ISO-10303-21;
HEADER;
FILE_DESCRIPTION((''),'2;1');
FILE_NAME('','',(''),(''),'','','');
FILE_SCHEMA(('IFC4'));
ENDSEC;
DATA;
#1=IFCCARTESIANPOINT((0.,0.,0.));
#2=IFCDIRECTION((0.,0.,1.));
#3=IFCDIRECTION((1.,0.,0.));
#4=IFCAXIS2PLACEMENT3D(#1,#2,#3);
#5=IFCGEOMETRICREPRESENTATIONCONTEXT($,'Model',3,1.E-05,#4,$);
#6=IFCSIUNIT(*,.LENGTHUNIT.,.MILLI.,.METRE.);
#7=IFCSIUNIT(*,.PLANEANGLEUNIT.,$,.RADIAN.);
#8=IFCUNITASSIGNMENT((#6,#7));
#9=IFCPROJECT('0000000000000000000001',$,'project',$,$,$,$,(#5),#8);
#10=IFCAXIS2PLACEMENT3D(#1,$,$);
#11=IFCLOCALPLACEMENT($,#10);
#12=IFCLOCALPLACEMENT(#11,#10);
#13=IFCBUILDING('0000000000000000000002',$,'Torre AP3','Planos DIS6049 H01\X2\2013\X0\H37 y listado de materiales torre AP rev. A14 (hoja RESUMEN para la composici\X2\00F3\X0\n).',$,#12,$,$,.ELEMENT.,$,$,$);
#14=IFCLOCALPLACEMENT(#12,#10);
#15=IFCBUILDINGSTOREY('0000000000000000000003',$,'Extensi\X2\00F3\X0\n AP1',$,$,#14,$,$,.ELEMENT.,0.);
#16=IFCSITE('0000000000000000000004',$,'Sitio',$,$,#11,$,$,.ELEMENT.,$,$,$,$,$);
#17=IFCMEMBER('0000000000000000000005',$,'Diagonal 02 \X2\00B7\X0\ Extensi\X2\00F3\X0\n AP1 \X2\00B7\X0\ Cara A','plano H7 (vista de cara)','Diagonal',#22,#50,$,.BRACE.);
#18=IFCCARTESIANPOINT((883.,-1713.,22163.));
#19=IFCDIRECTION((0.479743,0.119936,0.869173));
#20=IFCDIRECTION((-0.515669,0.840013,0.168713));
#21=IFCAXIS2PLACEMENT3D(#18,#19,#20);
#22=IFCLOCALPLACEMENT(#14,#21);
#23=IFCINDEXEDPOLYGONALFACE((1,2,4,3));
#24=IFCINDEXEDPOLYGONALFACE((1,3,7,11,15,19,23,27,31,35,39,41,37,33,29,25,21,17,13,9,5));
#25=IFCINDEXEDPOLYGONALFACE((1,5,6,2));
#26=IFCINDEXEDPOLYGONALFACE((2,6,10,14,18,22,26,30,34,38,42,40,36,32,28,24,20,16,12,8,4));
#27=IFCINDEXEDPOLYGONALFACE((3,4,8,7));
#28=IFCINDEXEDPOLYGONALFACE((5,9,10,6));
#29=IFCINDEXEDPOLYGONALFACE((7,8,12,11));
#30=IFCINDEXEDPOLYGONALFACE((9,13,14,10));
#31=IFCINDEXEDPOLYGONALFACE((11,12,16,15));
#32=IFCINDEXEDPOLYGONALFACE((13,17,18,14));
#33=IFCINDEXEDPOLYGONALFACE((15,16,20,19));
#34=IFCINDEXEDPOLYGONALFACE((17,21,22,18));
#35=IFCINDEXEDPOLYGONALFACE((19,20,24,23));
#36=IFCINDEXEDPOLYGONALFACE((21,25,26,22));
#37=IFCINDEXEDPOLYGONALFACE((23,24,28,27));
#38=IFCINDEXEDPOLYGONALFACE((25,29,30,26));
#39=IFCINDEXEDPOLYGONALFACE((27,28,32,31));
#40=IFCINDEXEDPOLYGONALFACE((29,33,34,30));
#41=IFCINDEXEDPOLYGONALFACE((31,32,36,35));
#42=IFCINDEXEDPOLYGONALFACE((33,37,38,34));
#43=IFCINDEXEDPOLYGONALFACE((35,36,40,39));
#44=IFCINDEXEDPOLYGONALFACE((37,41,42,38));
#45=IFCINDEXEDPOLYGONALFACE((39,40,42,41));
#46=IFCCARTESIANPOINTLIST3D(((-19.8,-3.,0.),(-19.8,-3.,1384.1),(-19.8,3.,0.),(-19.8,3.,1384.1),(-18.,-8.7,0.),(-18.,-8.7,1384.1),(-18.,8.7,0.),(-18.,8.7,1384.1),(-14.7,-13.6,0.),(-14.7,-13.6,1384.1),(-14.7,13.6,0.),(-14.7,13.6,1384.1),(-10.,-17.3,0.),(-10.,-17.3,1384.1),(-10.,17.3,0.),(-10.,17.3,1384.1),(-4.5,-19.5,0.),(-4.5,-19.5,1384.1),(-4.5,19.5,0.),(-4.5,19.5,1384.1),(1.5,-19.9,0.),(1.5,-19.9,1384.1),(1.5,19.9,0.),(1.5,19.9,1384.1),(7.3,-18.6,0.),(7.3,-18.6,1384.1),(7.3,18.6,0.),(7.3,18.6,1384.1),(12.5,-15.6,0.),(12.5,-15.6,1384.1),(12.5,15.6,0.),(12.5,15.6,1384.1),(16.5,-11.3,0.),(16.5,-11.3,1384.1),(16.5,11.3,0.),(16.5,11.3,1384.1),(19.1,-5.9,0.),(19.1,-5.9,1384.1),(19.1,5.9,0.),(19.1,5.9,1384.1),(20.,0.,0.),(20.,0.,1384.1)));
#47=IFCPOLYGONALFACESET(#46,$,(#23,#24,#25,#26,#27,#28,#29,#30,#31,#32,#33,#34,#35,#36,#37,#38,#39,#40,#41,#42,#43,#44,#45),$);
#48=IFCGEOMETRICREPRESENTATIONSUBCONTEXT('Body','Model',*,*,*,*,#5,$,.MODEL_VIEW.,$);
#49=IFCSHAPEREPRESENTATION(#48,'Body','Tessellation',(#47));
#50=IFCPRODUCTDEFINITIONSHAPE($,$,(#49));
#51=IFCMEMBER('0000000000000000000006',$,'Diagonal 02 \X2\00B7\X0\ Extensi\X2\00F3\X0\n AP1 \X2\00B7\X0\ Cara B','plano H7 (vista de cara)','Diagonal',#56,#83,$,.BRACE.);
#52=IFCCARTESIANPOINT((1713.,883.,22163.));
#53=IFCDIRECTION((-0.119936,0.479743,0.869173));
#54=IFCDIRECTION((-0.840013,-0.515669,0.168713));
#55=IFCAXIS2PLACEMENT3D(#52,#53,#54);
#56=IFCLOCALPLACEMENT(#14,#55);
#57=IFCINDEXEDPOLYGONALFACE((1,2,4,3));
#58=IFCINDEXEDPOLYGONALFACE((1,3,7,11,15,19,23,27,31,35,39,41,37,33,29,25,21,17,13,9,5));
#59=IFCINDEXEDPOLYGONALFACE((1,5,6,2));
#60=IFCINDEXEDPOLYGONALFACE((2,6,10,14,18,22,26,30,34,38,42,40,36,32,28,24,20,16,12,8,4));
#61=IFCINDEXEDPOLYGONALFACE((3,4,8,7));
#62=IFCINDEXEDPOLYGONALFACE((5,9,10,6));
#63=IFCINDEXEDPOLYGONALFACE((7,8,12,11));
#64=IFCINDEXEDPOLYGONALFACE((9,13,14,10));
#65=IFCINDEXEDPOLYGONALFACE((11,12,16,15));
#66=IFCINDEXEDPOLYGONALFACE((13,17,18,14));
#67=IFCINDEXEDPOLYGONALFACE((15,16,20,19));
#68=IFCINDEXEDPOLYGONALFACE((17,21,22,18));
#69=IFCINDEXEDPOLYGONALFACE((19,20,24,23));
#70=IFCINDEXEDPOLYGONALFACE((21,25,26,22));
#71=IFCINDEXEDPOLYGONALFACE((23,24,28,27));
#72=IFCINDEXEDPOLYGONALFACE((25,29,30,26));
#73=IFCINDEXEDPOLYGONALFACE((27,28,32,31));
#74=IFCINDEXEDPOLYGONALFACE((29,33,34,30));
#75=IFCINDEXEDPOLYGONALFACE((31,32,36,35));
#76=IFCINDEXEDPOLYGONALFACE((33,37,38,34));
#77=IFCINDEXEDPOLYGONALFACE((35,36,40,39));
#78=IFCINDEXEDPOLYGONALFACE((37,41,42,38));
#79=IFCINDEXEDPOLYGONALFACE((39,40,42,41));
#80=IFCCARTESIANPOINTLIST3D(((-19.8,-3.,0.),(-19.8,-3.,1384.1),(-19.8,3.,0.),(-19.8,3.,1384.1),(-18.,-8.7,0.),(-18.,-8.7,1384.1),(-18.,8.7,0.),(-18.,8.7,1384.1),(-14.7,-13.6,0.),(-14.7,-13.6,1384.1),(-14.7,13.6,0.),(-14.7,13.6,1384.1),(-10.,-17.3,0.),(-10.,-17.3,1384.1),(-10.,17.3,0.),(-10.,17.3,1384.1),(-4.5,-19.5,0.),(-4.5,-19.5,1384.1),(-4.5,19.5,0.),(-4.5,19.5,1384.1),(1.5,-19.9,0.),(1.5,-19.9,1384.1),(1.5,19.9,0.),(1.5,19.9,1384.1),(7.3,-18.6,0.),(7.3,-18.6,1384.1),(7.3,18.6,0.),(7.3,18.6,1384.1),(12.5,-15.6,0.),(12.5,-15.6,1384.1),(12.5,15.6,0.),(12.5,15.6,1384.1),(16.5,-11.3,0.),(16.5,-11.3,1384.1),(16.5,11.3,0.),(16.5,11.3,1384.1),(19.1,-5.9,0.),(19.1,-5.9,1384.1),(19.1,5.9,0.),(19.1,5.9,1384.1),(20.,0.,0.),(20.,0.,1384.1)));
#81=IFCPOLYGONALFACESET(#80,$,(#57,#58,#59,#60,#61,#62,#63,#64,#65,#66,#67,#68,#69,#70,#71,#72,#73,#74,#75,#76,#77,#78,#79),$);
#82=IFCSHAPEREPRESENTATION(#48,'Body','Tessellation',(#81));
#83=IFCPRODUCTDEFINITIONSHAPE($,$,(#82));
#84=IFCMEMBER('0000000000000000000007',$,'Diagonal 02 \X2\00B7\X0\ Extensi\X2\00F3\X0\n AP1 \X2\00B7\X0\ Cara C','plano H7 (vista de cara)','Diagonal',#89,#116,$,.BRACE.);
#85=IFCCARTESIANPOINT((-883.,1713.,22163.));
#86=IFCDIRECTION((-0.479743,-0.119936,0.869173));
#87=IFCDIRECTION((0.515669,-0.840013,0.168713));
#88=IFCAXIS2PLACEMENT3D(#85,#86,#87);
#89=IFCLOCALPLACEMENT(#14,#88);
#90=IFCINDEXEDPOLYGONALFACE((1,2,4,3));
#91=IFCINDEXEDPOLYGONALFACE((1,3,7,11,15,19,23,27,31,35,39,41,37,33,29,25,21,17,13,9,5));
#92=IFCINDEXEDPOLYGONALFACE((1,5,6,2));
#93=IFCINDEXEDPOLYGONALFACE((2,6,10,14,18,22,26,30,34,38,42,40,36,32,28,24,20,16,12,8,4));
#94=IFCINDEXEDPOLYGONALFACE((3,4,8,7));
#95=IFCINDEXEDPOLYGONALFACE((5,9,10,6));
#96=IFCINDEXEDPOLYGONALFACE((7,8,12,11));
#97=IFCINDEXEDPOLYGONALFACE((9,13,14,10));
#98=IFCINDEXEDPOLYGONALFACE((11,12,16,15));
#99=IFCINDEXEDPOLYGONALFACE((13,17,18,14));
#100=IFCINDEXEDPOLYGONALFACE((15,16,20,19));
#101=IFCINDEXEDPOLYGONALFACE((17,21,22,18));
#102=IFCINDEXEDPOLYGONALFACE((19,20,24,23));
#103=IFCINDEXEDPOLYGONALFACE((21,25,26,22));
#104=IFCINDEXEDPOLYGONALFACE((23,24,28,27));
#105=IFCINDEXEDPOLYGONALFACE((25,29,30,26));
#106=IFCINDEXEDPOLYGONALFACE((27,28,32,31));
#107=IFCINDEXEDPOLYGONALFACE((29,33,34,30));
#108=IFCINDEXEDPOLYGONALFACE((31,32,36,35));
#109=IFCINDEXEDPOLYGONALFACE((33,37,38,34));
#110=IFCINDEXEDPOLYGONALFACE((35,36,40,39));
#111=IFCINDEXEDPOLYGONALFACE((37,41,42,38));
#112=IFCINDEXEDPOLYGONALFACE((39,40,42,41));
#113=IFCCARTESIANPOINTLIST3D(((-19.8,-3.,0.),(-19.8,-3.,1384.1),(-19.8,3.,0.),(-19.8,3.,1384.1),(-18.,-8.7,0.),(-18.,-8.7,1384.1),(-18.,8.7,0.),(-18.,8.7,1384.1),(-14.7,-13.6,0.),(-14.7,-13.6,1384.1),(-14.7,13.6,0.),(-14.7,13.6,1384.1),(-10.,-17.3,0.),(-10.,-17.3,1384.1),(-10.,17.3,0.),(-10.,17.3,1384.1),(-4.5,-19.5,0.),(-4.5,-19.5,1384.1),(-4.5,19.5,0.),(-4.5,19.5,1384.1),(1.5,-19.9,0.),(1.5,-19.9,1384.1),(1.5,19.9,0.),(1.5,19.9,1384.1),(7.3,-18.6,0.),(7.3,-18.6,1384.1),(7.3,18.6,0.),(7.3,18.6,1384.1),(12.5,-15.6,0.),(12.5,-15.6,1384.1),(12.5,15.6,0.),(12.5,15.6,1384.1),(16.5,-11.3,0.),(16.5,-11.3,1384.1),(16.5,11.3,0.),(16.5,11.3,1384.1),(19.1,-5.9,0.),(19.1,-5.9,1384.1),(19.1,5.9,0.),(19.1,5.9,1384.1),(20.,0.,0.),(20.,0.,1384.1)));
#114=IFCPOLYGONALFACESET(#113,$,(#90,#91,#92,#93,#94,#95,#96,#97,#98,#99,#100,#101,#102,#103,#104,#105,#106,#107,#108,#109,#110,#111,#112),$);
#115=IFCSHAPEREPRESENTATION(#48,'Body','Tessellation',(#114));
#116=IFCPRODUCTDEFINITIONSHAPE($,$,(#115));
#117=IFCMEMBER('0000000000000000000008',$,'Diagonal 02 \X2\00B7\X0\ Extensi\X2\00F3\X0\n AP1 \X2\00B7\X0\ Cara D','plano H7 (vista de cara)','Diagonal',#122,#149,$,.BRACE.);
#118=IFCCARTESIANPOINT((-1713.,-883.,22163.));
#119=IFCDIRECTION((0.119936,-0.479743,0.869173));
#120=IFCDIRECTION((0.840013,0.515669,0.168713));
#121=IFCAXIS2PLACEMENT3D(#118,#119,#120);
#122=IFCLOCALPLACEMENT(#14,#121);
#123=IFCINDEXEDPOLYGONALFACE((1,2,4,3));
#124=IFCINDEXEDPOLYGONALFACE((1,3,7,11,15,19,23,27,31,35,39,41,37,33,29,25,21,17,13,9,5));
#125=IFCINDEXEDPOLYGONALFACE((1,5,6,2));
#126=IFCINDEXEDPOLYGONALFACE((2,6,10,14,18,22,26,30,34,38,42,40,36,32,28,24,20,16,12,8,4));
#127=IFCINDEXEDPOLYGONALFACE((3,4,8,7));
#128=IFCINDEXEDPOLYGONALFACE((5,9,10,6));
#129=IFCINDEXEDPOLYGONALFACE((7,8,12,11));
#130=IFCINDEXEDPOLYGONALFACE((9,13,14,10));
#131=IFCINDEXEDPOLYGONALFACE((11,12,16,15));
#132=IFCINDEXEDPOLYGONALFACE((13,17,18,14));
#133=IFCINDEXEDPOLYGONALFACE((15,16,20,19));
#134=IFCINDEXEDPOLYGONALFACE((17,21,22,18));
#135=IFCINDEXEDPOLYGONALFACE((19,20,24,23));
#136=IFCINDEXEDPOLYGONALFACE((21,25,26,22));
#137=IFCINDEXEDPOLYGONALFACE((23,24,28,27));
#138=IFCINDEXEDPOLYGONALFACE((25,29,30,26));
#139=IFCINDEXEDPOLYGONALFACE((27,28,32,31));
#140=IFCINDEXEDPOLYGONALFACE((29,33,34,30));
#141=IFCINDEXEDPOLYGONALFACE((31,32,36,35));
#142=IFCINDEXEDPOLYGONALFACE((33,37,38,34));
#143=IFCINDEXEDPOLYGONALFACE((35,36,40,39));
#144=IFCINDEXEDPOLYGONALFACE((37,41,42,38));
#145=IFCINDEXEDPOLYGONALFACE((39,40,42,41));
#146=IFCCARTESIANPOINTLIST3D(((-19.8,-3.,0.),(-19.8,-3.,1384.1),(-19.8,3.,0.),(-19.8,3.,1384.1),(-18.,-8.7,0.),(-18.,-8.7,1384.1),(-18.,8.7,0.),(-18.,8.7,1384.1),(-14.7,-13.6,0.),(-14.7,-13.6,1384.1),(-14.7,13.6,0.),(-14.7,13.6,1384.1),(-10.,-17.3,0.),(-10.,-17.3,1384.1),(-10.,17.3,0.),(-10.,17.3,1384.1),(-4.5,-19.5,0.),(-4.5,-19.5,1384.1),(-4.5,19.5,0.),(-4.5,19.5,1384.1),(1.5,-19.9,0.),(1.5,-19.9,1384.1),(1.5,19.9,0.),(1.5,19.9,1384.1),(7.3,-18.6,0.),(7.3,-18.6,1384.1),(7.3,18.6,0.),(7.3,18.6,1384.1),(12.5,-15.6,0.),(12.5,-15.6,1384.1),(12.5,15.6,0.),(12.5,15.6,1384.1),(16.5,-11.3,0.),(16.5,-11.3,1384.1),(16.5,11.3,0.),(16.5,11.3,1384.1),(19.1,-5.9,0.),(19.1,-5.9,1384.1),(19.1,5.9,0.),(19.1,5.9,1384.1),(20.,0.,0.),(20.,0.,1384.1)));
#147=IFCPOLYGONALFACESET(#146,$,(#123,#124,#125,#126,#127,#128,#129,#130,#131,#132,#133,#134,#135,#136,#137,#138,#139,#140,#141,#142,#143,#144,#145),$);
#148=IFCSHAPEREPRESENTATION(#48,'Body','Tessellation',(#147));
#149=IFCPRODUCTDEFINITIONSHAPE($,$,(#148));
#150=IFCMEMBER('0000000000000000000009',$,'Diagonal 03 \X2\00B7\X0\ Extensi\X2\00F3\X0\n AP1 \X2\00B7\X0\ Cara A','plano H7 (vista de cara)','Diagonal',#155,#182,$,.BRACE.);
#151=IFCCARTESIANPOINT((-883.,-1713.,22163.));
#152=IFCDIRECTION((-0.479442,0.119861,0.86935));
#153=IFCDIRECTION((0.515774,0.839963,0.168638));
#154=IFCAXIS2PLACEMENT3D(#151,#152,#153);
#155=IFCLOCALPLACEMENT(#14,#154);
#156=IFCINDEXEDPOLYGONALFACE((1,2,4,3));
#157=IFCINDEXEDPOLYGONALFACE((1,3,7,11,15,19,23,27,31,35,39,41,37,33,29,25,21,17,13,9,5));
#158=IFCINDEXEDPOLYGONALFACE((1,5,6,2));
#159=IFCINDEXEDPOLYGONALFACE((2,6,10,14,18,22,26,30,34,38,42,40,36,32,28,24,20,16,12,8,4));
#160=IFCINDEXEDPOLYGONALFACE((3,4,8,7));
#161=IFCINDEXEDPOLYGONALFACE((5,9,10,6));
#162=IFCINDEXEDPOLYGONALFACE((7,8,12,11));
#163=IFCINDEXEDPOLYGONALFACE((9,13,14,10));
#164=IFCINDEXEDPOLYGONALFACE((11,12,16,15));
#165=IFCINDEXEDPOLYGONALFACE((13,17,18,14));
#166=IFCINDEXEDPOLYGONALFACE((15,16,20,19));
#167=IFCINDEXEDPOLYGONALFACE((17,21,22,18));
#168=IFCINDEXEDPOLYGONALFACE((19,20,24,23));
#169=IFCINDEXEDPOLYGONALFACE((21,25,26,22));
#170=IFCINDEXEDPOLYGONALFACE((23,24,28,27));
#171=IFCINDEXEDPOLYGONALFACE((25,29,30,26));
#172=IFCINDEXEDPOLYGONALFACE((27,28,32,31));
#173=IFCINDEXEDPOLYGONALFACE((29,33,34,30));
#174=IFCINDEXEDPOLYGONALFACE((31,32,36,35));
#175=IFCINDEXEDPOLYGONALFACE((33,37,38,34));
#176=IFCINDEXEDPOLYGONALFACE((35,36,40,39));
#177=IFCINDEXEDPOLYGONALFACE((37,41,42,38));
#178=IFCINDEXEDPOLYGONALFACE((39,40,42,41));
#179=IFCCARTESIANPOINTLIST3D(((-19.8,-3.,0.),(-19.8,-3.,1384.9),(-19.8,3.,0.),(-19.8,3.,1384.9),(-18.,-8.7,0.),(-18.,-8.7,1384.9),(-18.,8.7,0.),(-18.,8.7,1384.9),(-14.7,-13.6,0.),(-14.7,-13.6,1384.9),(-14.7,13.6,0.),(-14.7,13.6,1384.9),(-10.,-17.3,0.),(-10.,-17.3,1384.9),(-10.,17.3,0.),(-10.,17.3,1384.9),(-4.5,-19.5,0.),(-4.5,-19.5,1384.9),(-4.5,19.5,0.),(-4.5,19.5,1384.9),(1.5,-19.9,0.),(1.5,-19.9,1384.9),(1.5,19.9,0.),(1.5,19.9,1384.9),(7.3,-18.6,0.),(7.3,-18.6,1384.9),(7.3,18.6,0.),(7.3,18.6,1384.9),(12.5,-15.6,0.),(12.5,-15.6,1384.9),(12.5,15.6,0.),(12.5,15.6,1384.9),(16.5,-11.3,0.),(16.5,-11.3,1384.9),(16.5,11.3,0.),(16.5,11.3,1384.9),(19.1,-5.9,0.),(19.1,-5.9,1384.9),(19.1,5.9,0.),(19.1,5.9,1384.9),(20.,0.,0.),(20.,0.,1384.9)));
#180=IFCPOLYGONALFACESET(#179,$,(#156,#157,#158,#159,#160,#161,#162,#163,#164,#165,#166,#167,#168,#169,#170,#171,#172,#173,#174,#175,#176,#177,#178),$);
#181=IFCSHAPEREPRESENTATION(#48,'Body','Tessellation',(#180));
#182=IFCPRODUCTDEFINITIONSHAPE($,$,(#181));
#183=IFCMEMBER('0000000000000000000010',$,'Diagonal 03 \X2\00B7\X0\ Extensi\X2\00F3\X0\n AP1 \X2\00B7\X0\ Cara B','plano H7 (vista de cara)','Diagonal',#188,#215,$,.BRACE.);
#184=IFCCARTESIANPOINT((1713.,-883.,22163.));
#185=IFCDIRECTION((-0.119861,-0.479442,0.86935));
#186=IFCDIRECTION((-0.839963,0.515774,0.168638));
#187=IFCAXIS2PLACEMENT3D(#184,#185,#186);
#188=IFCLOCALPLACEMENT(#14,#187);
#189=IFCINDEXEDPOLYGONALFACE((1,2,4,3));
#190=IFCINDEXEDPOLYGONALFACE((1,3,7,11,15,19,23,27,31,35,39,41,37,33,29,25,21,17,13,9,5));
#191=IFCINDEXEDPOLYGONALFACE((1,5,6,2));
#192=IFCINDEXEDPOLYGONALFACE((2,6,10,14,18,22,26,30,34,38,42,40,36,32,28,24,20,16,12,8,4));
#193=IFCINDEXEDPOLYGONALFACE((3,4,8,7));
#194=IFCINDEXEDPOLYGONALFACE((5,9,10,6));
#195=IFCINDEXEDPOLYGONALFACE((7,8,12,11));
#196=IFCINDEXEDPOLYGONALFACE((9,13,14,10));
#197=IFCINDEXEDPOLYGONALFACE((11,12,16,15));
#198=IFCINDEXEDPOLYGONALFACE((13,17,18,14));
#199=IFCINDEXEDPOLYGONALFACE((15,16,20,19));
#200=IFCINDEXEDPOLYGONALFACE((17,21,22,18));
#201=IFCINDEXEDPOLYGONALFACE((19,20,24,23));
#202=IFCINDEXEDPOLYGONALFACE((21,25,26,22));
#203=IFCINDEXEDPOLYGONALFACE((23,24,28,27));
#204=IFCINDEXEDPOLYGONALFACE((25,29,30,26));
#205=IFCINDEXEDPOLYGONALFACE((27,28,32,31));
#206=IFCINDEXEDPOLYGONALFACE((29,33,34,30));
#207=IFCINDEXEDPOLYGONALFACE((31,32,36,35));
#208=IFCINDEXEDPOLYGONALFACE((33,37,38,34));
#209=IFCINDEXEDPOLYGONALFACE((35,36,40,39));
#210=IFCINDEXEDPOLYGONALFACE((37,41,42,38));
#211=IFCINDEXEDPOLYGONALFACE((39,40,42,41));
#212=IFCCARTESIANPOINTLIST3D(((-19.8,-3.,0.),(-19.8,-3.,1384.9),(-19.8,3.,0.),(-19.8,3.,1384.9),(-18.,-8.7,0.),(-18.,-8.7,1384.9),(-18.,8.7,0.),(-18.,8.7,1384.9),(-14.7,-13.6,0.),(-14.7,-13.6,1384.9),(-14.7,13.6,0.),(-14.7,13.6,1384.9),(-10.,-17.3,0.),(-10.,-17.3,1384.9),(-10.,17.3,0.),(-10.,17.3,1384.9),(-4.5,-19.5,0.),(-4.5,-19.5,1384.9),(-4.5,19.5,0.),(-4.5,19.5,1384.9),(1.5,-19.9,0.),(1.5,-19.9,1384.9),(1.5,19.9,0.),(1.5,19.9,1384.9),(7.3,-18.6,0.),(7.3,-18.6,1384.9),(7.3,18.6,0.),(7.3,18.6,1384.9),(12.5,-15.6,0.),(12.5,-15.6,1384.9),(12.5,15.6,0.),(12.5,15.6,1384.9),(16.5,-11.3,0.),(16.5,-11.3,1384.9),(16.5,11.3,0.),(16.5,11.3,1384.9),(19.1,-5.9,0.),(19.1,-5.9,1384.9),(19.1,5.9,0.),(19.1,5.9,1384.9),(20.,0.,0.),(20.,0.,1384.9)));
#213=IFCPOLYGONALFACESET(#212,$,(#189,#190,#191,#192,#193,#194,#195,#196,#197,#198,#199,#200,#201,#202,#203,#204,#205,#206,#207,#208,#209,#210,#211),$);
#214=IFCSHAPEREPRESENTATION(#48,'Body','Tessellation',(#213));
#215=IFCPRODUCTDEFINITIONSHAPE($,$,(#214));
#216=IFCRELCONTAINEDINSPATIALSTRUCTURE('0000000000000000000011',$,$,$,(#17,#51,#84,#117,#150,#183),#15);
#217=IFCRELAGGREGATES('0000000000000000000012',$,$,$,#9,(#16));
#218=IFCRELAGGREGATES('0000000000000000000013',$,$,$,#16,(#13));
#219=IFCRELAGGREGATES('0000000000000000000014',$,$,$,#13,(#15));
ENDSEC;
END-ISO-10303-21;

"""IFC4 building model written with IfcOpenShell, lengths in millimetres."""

from ifc_helpers import new_model, si_unit, frame, origin, origin_with_axes, place, context, subcontext, project, spatial, circle, extrude, element, save


model = new_model("IFC4")

# Units and contexts
model_context = context("Model", 3, precision=1e-05, world=origin_with_axes())
body_context = subcontext(model_context, "Body", "Model", "MODEL_VIEW")
ifc_project = project(units=[si_unit("LENGTHUNIT", "METRE", prefix="MILLI"), si_unit("PLANEANGLEUNIT", "RADIAN")], contexts=[model_context])

# Site, building, storey
site_placement = place(None, origin())
site = spatial("IfcSite", under=ifc_project, at=site_placement, Name="Sitio", CompositionType="ELEMENT")
building_placement = place(site_placement, origin())
building = spatial("IfcBuilding", under=site, at=building_placement, Name="Torre AP3", Description="Planos DIS6049 H01–H37 y listado de materiales torre AP rev. A14 (hoja RESUMEN para la composición).", CompositionType="ELEMENT")
storey_placement = place(building_placement, origin())
storey = spatial("IfcBuildingStorey", under=building, at=storey_placement, Name="Extensión AP1", CompositionType="ELEMENT", Elevation=0.0)

# Members
for number, where, z_axis, x_axis, name in (
    (1, (883.0, -1713.0, 22163.0), (0.479743, 0.119936, 0.869173), (-0.515669, 0.840013, 0.168713), "Diagonal 02 · Extensión AP1 · Cara A"),
    (2, (1713.0, 883.0, 22163.0), (-0.119936, 0.479743, 0.869173), (-0.840013, -0.515669, 0.168713), "Diagonal 02 · Extensión AP1 · Cara B"),
    (3, (-883.0, 1713.0, 22163.0), (-0.479743, -0.119936, 0.869173), (0.515669, -0.840013, 0.168713), "Diagonal 02 · Extensión AP1 · Cara C"),
    (4, (-1713.0, -883.0, 22163.0), (0.119936, -0.479743, 0.869173), (0.840013, 0.515669, 0.168713), "Diagonal 02 · Extensión AP1 · Cara D"),
):
    element("IfcMember", number, at=place(storey_placement, frame(where, z_axis=z_axis, x_axis=x_axis)), inside=storey, Name=name, Description="plano H7 (vista de cara)", ObjectType="Diagonal", PredefinedType="BRACE", context=body_context, shape_type="SweptSolid", body=[
        extrude(circle(Radius=20.0), None, (0.0, 0.0, 1.0), 1384.1),
    ])
for number, where, z_axis, x_axis, name in (
    (5, (-883.0, -1713.0, 22163.0), (-0.479442, 0.119861, 0.86935), (0.515774, 0.839963, 0.168638), "Diagonal 03 · Extensión AP1 · Cara A"),
    (6, (1713.0, -883.0, 22163.0), (-0.119861, -0.479442, 0.86935), (-0.839963, 0.515774, 0.168638), "Diagonal 03 · Extensión AP1 · Cara B"),
):
    element("IfcMember", number, at=place(storey_placement, frame(where, z_axis=z_axis, x_axis=x_axis)), inside=storey, Name=name, Description="plano H7 (vista de cara)", ObjectType="Diagonal", PredefinedType="BRACE", context=body_context, shape_type="SweptSolid", body=[
        extrude(circle(Radius=20.0), None, (0.0, 0.0, 1.0), 1384.9),
    ])

save(model, "model.ifc")
